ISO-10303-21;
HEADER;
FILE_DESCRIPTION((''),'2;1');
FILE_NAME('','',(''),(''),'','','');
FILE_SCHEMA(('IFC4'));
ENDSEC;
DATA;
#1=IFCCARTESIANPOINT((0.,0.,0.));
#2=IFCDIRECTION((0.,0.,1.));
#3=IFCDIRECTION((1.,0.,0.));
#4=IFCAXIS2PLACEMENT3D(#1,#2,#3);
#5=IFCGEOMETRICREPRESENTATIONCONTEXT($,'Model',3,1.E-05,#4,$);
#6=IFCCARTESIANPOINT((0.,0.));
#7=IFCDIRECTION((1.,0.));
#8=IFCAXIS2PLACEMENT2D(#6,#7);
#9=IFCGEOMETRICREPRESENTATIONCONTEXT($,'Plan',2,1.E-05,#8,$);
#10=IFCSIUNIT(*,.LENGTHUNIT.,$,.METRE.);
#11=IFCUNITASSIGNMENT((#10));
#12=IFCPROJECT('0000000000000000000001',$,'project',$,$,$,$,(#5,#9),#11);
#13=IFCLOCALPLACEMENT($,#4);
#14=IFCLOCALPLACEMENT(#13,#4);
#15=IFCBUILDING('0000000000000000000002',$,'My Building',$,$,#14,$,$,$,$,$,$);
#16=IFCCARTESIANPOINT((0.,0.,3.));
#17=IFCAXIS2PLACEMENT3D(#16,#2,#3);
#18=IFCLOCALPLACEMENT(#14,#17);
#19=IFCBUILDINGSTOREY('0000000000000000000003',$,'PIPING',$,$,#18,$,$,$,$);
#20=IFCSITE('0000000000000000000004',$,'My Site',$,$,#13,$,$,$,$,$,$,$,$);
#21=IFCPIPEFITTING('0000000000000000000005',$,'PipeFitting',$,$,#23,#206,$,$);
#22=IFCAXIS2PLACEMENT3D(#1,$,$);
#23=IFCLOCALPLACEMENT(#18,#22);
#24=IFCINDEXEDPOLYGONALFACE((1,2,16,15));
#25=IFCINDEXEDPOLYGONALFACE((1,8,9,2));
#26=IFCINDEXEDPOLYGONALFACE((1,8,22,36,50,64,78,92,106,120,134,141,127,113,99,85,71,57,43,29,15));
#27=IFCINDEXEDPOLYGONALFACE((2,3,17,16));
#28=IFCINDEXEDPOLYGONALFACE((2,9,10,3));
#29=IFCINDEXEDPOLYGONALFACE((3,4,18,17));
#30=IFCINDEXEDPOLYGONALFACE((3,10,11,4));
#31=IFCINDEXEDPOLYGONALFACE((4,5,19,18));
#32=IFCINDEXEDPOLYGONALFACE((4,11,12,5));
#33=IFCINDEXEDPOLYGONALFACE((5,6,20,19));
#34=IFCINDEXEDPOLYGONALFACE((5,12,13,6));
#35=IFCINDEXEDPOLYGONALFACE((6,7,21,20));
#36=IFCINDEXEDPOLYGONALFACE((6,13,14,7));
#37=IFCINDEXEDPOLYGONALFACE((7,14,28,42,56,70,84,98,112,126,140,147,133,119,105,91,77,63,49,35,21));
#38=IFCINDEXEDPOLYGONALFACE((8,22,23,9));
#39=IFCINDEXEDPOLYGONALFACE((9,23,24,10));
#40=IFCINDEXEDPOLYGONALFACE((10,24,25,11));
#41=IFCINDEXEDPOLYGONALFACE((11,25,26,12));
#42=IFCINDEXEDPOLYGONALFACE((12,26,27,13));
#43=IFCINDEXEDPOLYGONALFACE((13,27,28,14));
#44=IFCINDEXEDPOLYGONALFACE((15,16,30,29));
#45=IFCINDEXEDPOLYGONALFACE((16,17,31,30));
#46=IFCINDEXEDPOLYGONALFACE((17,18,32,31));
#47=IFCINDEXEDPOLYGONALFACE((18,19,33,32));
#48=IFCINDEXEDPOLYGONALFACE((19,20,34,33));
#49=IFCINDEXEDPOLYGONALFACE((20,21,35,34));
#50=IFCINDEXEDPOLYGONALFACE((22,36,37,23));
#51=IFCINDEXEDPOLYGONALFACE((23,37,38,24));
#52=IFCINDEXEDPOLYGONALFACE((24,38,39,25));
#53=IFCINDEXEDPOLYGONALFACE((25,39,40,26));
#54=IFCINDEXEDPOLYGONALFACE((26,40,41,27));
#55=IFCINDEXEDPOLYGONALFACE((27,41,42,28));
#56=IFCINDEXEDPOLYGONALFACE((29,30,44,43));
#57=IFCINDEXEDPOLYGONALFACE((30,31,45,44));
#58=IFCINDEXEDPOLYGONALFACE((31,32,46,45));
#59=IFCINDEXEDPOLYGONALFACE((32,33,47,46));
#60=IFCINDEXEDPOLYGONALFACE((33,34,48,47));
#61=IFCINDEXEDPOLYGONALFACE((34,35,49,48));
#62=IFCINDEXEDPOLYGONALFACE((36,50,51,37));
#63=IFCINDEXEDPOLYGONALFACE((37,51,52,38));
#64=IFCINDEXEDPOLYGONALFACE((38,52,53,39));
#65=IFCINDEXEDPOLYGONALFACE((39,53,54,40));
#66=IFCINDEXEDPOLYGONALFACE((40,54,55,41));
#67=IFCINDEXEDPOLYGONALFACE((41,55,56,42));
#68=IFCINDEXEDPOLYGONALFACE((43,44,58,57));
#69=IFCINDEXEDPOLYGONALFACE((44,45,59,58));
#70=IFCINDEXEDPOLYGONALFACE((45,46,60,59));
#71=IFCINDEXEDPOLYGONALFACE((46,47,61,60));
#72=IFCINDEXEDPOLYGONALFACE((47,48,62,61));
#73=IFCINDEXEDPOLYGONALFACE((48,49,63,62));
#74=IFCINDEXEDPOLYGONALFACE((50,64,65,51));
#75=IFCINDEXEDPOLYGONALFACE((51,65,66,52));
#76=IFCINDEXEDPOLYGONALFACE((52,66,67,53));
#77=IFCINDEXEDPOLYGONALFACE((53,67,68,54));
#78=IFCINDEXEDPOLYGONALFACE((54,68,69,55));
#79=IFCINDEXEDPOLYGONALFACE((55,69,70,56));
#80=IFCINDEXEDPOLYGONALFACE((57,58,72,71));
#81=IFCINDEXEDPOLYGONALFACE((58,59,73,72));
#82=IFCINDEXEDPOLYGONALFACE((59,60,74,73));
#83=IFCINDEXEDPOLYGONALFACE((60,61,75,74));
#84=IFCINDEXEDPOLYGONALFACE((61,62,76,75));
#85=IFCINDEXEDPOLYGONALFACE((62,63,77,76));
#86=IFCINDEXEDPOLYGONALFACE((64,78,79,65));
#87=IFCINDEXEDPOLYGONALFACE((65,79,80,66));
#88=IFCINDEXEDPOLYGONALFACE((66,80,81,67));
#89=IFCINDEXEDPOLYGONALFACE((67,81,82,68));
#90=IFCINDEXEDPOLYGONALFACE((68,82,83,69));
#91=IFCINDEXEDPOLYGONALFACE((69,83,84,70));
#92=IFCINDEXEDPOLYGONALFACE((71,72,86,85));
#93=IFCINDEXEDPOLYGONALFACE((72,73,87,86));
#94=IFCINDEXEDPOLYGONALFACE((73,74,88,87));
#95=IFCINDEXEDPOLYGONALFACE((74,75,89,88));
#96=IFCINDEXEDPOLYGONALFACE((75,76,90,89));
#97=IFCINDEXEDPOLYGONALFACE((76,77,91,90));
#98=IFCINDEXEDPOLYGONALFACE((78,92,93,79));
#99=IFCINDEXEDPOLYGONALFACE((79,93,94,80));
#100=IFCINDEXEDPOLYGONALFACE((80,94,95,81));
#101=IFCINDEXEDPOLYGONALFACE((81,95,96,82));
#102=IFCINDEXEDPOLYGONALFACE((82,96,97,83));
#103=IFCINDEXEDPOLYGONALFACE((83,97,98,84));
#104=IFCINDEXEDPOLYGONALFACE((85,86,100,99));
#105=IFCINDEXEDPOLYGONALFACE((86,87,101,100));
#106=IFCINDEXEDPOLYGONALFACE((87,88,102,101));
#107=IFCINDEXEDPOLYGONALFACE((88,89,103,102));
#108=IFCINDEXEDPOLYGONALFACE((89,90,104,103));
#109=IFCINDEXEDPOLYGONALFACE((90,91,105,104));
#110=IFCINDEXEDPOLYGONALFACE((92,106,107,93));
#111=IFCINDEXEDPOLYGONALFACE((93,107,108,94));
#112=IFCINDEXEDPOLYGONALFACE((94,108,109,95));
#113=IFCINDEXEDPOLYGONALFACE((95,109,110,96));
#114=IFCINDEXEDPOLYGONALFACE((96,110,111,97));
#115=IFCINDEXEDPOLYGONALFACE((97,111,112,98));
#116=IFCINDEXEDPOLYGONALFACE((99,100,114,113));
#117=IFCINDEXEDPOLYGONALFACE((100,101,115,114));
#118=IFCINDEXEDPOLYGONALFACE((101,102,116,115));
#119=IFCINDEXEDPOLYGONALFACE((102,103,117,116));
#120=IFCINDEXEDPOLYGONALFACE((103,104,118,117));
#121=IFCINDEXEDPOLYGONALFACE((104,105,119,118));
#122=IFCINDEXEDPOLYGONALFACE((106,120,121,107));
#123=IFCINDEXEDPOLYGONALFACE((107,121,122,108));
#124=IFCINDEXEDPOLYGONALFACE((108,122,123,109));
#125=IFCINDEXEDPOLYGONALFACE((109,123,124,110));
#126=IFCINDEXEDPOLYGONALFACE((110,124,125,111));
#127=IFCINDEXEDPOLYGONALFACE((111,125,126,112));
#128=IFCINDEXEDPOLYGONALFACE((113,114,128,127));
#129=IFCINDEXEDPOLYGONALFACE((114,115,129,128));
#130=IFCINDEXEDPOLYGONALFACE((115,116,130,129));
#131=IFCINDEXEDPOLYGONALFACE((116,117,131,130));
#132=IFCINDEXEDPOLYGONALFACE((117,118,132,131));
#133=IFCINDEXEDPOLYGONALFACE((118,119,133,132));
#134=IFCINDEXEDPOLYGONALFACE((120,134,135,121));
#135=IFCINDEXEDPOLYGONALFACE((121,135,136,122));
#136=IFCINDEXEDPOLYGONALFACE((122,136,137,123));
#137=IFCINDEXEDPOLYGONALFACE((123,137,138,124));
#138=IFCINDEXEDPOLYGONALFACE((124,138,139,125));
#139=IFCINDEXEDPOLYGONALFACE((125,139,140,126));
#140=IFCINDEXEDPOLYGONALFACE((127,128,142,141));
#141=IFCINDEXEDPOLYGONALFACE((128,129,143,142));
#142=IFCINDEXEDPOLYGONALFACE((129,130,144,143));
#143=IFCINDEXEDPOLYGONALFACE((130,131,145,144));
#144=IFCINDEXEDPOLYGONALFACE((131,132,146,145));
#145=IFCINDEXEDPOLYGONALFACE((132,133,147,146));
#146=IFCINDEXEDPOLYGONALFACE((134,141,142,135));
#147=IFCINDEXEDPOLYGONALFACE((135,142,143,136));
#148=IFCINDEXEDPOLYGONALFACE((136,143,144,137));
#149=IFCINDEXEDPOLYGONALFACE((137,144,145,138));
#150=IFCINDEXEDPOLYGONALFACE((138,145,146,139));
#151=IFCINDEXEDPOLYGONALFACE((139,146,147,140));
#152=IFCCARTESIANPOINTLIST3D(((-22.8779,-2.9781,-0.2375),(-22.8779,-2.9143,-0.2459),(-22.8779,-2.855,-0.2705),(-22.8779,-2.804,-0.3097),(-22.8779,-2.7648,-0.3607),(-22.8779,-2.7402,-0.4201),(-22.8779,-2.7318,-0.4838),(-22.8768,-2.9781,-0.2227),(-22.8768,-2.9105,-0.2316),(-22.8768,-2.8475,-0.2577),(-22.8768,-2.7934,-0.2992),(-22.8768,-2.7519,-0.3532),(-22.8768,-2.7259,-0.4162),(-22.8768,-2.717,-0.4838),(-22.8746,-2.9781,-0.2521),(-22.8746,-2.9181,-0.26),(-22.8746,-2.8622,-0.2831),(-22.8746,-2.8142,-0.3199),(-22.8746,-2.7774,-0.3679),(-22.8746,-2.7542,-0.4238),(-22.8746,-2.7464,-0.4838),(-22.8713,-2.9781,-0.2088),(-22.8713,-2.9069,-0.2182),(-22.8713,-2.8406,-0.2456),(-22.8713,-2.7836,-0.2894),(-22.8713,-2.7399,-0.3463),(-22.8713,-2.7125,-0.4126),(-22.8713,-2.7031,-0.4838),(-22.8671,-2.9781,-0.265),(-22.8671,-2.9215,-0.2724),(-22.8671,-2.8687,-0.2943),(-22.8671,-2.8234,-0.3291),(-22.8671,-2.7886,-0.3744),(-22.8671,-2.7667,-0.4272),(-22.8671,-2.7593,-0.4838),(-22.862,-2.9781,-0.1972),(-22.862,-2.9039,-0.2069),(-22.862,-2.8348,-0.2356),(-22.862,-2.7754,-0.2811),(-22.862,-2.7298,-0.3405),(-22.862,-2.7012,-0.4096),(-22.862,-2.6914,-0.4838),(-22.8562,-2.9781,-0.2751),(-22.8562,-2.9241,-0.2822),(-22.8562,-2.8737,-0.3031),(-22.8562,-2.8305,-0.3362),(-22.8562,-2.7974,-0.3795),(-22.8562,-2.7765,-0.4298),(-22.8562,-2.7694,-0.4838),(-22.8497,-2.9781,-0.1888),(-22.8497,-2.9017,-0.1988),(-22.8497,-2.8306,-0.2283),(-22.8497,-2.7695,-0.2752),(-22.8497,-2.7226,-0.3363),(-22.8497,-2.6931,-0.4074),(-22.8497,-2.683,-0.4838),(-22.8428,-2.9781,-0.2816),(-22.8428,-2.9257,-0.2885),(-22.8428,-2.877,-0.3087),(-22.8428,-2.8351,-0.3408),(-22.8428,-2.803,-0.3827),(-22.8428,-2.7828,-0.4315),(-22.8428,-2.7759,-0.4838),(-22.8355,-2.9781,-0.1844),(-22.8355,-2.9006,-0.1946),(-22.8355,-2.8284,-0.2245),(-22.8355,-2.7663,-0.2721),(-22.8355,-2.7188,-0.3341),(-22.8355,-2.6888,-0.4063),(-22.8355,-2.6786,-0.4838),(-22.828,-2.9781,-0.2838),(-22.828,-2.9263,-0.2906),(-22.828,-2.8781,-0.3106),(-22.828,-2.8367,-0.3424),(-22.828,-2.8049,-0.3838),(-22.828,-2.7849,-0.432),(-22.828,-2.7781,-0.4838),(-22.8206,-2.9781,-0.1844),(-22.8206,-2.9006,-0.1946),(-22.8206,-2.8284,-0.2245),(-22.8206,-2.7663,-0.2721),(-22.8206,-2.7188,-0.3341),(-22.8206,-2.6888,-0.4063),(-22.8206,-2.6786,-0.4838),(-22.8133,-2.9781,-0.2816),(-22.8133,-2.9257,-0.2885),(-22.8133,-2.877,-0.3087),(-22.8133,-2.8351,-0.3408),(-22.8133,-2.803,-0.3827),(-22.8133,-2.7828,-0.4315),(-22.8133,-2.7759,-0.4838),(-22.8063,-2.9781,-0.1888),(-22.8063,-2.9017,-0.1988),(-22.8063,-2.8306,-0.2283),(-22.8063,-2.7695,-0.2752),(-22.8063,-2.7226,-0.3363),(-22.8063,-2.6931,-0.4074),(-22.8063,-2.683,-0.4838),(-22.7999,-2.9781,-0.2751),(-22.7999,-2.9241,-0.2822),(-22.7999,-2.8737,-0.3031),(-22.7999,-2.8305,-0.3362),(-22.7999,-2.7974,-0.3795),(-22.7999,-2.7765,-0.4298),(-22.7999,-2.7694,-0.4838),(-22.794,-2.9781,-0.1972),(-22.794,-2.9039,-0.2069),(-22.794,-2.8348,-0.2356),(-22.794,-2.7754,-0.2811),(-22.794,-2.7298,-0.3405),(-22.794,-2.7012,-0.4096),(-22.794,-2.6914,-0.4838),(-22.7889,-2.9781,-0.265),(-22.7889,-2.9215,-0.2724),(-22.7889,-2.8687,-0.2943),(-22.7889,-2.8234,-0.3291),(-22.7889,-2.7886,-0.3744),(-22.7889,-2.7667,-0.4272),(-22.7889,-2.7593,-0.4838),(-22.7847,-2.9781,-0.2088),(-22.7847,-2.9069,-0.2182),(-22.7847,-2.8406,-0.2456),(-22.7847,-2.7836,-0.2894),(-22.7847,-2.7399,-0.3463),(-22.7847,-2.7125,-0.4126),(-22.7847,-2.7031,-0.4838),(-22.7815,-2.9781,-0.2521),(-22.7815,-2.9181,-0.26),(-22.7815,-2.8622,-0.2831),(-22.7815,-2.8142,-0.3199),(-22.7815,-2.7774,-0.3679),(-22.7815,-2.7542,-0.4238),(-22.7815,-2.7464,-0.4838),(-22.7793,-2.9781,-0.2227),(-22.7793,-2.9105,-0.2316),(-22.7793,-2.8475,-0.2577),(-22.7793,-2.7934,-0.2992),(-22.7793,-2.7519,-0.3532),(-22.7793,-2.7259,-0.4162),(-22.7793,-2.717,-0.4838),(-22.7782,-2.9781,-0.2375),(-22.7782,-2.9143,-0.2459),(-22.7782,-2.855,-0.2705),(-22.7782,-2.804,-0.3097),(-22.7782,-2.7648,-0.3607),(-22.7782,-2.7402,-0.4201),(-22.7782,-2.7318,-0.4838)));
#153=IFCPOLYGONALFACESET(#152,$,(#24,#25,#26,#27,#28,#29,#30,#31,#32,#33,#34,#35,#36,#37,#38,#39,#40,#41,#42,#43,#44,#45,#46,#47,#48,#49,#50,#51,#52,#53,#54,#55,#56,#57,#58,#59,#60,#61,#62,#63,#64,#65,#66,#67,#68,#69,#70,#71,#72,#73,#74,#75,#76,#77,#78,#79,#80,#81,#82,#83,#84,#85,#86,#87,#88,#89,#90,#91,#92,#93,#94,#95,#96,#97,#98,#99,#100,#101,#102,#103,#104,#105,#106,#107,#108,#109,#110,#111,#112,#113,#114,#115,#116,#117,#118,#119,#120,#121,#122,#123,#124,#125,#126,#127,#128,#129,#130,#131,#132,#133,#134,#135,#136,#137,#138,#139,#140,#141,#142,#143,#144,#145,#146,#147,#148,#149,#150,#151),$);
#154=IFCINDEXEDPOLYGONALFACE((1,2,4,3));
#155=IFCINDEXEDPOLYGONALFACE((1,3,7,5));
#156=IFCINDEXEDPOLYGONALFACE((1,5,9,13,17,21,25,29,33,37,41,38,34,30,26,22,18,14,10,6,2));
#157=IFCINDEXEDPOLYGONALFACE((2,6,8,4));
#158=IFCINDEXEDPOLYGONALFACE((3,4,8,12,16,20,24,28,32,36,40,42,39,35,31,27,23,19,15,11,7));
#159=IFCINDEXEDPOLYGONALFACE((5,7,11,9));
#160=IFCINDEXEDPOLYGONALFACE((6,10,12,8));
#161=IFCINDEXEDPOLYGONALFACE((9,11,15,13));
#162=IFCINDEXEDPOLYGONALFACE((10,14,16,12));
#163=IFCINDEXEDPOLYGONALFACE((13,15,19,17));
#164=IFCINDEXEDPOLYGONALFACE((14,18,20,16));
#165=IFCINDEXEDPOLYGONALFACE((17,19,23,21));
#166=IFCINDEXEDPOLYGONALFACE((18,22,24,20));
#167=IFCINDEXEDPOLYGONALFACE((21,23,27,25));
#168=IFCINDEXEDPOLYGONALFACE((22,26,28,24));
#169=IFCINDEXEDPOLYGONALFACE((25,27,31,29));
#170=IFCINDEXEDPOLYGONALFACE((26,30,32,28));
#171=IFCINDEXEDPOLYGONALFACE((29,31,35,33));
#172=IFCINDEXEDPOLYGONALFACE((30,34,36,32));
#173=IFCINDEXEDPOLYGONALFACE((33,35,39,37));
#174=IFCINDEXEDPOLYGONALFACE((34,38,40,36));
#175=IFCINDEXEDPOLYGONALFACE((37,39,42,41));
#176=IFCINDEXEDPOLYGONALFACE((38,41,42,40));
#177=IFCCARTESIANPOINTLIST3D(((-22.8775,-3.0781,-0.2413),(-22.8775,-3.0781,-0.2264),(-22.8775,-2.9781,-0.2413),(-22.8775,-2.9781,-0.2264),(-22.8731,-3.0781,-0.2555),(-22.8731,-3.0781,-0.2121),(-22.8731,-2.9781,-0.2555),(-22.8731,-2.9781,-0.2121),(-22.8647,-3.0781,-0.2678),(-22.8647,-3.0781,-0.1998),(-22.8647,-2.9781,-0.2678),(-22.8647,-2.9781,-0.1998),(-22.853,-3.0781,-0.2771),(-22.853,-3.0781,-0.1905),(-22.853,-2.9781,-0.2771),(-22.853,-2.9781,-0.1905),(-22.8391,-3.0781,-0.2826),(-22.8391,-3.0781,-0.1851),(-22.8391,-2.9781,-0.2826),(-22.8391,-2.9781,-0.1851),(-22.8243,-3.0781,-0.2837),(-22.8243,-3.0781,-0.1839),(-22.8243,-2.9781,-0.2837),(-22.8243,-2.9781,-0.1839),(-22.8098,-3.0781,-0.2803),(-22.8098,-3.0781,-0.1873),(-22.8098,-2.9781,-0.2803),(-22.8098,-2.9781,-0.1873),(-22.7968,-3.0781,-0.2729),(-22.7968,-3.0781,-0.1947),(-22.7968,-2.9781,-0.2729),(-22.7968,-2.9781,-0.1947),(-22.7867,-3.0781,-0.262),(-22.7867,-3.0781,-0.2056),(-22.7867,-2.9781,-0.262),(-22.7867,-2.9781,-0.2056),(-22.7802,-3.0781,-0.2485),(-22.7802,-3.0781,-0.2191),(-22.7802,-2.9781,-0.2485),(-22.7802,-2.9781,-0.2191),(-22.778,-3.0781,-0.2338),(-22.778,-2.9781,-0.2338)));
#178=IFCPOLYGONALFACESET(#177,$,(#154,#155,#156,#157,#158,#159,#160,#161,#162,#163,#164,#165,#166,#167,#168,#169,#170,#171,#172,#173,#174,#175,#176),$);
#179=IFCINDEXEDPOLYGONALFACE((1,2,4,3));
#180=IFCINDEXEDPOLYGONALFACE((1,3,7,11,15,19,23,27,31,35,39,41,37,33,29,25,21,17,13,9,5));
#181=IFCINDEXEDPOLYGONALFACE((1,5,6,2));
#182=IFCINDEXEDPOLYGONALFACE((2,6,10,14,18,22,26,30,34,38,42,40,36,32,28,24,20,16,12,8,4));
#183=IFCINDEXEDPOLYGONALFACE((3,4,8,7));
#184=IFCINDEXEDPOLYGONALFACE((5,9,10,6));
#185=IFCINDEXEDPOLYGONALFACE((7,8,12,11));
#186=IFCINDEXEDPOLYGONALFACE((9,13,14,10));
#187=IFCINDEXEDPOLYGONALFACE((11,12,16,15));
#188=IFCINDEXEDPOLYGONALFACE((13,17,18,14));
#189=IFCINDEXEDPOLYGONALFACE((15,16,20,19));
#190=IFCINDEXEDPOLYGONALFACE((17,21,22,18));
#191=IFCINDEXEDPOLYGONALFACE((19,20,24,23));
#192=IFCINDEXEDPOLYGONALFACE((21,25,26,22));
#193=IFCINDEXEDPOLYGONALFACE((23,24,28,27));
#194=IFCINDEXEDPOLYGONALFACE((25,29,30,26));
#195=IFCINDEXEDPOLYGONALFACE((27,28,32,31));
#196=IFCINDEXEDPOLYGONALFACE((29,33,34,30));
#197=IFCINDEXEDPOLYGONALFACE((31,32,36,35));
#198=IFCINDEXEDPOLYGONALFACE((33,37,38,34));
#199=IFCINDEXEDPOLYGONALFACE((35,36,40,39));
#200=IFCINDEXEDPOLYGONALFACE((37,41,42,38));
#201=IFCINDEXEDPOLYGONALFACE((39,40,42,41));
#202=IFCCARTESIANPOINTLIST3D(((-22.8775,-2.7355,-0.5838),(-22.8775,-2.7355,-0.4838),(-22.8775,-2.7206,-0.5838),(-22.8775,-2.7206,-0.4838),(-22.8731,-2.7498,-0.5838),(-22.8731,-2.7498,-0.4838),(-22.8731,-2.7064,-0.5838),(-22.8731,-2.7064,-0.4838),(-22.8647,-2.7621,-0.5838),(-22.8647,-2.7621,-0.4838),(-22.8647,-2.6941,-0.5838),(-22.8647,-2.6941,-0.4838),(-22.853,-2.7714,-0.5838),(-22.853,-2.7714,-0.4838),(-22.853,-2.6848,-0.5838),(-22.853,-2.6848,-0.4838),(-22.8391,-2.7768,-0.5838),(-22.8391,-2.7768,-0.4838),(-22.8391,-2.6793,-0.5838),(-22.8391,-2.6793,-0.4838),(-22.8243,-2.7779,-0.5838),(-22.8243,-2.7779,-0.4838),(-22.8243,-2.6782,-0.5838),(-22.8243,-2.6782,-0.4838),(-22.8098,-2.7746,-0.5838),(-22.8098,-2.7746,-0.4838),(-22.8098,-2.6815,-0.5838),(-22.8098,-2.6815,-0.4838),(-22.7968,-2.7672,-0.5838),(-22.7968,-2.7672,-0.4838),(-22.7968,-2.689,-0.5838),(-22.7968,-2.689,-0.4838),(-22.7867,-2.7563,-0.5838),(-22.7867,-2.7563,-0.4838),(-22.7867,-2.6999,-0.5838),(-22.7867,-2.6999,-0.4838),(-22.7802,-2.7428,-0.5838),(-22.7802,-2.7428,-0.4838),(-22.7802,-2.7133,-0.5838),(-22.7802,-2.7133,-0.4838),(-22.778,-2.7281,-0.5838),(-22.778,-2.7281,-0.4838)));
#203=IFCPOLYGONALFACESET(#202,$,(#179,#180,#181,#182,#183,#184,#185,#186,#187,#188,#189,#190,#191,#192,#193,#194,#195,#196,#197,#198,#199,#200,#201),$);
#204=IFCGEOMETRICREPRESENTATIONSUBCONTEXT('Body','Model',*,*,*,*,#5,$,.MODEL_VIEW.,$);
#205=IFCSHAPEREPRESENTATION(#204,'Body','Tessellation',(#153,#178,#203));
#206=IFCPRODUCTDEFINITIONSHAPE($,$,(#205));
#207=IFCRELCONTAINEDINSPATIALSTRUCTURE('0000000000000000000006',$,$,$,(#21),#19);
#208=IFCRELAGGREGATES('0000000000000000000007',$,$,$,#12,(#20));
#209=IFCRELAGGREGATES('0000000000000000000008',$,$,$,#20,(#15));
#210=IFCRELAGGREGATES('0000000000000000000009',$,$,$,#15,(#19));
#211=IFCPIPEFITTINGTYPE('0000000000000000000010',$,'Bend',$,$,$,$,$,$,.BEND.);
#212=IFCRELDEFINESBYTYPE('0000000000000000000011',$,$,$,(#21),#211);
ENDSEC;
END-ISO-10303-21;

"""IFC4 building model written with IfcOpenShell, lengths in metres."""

from ifc_helpers import new_model, entity, si_unit, frame, origin_with_axes, origin_2d_with_axis, place, context, subcontext, project, spatial, circle, extrude, source, transform, mapped, type_object, type_shapes, element, save


model = new_model("IFC4")

# Units and contexts
model_context = context("Model", 3, precision=1e-05, world=origin_with_axes())
plan_context = context("Plan", 2, precision=1e-05, world=origin_2d_with_axis())
body_context = subcontext(model_context, "Body", "Model", "MODEL_VIEW")
ifc_project = project(units=[si_unit("LENGTHUNIT", "METRE")], contexts=[model_context, plan_context])

# Site, building, storey
site_placement = place(None, origin_with_axes())
site = spatial("IfcSite", under=ifc_project, at=site_placement, Name="My Site")
building_placement = place(site_placement, origin_with_axes())
building = spatial("IfcBuilding", under=site, at=building_placement, Name="My Building")
storey_placement = place(building_placement, frame((0.0, 0.0, 3.0), z_axis=(0.0, 0.0, 1.0), x_axis=(1.0, 0.0, 0.0)))
storey = spatial("IfcBuildingStorey", under=building, at=storey_placement, Name="PIPING")

# Pipe fitting
pipe_fitting_type = type_object("IfcPipeFittingType", Name="Bend", PredefinedType="BEND")
shared_shape = source(origin_with_axes(), body_context, "Body", "SolidModel", [
    entity("IfcSweptDiskSolid", entity("IfcIndexedPolyCurve", entity("IfcCartesianPointList3D", [[0.0, 0.0, -0.1], [0.0, -0.0732, -0.2768], [0.0, -0.25, -0.35]]), [entity("IfcArcIndex", [1, 2, 3])]), 0.05),
    extrude(circle(Radius=0.05), origin_with_axes(), (0.0, 0.0, -1.0), 0.1),
    extrude(circle(Radius=0.05), frame((0.0, -0.25, -0.35), z_axis=(0.0, -1.0, 0.0), x_axis=(1.0, 0.0, 0.0)), (0.0, 0.0, 1.0), 0.1),
])
type_shapes(pipe_fitting_type, [shared_shape])
for number, where, z_axis, x_axis, name in (
    (1, (-22.828, -3.0781, -0.2338), (0.0, -1.0, 0.0), (1.0, 0.0, 0.0), "PipeFitting"),
):
    element("IfcPipeFitting", number, at=place(storey_placement, frame(where, z_axis=z_axis, x_axis=x_axis)), inside=storey, type_object=pipe_fitting_type, Name=name, context=body_context, shape_type="MappedRepresentation", body=[
        mapped(shared_shape, transform((0.0, 0.0, 0.0), x_axis=(1.0, 0.0, 0.0), y_axis=(0.0, 1.0, 0.0), z_axis=(0.0, 0.0, 1.0), scale=1.0)),
    ])

save(model, "model.ifc")
